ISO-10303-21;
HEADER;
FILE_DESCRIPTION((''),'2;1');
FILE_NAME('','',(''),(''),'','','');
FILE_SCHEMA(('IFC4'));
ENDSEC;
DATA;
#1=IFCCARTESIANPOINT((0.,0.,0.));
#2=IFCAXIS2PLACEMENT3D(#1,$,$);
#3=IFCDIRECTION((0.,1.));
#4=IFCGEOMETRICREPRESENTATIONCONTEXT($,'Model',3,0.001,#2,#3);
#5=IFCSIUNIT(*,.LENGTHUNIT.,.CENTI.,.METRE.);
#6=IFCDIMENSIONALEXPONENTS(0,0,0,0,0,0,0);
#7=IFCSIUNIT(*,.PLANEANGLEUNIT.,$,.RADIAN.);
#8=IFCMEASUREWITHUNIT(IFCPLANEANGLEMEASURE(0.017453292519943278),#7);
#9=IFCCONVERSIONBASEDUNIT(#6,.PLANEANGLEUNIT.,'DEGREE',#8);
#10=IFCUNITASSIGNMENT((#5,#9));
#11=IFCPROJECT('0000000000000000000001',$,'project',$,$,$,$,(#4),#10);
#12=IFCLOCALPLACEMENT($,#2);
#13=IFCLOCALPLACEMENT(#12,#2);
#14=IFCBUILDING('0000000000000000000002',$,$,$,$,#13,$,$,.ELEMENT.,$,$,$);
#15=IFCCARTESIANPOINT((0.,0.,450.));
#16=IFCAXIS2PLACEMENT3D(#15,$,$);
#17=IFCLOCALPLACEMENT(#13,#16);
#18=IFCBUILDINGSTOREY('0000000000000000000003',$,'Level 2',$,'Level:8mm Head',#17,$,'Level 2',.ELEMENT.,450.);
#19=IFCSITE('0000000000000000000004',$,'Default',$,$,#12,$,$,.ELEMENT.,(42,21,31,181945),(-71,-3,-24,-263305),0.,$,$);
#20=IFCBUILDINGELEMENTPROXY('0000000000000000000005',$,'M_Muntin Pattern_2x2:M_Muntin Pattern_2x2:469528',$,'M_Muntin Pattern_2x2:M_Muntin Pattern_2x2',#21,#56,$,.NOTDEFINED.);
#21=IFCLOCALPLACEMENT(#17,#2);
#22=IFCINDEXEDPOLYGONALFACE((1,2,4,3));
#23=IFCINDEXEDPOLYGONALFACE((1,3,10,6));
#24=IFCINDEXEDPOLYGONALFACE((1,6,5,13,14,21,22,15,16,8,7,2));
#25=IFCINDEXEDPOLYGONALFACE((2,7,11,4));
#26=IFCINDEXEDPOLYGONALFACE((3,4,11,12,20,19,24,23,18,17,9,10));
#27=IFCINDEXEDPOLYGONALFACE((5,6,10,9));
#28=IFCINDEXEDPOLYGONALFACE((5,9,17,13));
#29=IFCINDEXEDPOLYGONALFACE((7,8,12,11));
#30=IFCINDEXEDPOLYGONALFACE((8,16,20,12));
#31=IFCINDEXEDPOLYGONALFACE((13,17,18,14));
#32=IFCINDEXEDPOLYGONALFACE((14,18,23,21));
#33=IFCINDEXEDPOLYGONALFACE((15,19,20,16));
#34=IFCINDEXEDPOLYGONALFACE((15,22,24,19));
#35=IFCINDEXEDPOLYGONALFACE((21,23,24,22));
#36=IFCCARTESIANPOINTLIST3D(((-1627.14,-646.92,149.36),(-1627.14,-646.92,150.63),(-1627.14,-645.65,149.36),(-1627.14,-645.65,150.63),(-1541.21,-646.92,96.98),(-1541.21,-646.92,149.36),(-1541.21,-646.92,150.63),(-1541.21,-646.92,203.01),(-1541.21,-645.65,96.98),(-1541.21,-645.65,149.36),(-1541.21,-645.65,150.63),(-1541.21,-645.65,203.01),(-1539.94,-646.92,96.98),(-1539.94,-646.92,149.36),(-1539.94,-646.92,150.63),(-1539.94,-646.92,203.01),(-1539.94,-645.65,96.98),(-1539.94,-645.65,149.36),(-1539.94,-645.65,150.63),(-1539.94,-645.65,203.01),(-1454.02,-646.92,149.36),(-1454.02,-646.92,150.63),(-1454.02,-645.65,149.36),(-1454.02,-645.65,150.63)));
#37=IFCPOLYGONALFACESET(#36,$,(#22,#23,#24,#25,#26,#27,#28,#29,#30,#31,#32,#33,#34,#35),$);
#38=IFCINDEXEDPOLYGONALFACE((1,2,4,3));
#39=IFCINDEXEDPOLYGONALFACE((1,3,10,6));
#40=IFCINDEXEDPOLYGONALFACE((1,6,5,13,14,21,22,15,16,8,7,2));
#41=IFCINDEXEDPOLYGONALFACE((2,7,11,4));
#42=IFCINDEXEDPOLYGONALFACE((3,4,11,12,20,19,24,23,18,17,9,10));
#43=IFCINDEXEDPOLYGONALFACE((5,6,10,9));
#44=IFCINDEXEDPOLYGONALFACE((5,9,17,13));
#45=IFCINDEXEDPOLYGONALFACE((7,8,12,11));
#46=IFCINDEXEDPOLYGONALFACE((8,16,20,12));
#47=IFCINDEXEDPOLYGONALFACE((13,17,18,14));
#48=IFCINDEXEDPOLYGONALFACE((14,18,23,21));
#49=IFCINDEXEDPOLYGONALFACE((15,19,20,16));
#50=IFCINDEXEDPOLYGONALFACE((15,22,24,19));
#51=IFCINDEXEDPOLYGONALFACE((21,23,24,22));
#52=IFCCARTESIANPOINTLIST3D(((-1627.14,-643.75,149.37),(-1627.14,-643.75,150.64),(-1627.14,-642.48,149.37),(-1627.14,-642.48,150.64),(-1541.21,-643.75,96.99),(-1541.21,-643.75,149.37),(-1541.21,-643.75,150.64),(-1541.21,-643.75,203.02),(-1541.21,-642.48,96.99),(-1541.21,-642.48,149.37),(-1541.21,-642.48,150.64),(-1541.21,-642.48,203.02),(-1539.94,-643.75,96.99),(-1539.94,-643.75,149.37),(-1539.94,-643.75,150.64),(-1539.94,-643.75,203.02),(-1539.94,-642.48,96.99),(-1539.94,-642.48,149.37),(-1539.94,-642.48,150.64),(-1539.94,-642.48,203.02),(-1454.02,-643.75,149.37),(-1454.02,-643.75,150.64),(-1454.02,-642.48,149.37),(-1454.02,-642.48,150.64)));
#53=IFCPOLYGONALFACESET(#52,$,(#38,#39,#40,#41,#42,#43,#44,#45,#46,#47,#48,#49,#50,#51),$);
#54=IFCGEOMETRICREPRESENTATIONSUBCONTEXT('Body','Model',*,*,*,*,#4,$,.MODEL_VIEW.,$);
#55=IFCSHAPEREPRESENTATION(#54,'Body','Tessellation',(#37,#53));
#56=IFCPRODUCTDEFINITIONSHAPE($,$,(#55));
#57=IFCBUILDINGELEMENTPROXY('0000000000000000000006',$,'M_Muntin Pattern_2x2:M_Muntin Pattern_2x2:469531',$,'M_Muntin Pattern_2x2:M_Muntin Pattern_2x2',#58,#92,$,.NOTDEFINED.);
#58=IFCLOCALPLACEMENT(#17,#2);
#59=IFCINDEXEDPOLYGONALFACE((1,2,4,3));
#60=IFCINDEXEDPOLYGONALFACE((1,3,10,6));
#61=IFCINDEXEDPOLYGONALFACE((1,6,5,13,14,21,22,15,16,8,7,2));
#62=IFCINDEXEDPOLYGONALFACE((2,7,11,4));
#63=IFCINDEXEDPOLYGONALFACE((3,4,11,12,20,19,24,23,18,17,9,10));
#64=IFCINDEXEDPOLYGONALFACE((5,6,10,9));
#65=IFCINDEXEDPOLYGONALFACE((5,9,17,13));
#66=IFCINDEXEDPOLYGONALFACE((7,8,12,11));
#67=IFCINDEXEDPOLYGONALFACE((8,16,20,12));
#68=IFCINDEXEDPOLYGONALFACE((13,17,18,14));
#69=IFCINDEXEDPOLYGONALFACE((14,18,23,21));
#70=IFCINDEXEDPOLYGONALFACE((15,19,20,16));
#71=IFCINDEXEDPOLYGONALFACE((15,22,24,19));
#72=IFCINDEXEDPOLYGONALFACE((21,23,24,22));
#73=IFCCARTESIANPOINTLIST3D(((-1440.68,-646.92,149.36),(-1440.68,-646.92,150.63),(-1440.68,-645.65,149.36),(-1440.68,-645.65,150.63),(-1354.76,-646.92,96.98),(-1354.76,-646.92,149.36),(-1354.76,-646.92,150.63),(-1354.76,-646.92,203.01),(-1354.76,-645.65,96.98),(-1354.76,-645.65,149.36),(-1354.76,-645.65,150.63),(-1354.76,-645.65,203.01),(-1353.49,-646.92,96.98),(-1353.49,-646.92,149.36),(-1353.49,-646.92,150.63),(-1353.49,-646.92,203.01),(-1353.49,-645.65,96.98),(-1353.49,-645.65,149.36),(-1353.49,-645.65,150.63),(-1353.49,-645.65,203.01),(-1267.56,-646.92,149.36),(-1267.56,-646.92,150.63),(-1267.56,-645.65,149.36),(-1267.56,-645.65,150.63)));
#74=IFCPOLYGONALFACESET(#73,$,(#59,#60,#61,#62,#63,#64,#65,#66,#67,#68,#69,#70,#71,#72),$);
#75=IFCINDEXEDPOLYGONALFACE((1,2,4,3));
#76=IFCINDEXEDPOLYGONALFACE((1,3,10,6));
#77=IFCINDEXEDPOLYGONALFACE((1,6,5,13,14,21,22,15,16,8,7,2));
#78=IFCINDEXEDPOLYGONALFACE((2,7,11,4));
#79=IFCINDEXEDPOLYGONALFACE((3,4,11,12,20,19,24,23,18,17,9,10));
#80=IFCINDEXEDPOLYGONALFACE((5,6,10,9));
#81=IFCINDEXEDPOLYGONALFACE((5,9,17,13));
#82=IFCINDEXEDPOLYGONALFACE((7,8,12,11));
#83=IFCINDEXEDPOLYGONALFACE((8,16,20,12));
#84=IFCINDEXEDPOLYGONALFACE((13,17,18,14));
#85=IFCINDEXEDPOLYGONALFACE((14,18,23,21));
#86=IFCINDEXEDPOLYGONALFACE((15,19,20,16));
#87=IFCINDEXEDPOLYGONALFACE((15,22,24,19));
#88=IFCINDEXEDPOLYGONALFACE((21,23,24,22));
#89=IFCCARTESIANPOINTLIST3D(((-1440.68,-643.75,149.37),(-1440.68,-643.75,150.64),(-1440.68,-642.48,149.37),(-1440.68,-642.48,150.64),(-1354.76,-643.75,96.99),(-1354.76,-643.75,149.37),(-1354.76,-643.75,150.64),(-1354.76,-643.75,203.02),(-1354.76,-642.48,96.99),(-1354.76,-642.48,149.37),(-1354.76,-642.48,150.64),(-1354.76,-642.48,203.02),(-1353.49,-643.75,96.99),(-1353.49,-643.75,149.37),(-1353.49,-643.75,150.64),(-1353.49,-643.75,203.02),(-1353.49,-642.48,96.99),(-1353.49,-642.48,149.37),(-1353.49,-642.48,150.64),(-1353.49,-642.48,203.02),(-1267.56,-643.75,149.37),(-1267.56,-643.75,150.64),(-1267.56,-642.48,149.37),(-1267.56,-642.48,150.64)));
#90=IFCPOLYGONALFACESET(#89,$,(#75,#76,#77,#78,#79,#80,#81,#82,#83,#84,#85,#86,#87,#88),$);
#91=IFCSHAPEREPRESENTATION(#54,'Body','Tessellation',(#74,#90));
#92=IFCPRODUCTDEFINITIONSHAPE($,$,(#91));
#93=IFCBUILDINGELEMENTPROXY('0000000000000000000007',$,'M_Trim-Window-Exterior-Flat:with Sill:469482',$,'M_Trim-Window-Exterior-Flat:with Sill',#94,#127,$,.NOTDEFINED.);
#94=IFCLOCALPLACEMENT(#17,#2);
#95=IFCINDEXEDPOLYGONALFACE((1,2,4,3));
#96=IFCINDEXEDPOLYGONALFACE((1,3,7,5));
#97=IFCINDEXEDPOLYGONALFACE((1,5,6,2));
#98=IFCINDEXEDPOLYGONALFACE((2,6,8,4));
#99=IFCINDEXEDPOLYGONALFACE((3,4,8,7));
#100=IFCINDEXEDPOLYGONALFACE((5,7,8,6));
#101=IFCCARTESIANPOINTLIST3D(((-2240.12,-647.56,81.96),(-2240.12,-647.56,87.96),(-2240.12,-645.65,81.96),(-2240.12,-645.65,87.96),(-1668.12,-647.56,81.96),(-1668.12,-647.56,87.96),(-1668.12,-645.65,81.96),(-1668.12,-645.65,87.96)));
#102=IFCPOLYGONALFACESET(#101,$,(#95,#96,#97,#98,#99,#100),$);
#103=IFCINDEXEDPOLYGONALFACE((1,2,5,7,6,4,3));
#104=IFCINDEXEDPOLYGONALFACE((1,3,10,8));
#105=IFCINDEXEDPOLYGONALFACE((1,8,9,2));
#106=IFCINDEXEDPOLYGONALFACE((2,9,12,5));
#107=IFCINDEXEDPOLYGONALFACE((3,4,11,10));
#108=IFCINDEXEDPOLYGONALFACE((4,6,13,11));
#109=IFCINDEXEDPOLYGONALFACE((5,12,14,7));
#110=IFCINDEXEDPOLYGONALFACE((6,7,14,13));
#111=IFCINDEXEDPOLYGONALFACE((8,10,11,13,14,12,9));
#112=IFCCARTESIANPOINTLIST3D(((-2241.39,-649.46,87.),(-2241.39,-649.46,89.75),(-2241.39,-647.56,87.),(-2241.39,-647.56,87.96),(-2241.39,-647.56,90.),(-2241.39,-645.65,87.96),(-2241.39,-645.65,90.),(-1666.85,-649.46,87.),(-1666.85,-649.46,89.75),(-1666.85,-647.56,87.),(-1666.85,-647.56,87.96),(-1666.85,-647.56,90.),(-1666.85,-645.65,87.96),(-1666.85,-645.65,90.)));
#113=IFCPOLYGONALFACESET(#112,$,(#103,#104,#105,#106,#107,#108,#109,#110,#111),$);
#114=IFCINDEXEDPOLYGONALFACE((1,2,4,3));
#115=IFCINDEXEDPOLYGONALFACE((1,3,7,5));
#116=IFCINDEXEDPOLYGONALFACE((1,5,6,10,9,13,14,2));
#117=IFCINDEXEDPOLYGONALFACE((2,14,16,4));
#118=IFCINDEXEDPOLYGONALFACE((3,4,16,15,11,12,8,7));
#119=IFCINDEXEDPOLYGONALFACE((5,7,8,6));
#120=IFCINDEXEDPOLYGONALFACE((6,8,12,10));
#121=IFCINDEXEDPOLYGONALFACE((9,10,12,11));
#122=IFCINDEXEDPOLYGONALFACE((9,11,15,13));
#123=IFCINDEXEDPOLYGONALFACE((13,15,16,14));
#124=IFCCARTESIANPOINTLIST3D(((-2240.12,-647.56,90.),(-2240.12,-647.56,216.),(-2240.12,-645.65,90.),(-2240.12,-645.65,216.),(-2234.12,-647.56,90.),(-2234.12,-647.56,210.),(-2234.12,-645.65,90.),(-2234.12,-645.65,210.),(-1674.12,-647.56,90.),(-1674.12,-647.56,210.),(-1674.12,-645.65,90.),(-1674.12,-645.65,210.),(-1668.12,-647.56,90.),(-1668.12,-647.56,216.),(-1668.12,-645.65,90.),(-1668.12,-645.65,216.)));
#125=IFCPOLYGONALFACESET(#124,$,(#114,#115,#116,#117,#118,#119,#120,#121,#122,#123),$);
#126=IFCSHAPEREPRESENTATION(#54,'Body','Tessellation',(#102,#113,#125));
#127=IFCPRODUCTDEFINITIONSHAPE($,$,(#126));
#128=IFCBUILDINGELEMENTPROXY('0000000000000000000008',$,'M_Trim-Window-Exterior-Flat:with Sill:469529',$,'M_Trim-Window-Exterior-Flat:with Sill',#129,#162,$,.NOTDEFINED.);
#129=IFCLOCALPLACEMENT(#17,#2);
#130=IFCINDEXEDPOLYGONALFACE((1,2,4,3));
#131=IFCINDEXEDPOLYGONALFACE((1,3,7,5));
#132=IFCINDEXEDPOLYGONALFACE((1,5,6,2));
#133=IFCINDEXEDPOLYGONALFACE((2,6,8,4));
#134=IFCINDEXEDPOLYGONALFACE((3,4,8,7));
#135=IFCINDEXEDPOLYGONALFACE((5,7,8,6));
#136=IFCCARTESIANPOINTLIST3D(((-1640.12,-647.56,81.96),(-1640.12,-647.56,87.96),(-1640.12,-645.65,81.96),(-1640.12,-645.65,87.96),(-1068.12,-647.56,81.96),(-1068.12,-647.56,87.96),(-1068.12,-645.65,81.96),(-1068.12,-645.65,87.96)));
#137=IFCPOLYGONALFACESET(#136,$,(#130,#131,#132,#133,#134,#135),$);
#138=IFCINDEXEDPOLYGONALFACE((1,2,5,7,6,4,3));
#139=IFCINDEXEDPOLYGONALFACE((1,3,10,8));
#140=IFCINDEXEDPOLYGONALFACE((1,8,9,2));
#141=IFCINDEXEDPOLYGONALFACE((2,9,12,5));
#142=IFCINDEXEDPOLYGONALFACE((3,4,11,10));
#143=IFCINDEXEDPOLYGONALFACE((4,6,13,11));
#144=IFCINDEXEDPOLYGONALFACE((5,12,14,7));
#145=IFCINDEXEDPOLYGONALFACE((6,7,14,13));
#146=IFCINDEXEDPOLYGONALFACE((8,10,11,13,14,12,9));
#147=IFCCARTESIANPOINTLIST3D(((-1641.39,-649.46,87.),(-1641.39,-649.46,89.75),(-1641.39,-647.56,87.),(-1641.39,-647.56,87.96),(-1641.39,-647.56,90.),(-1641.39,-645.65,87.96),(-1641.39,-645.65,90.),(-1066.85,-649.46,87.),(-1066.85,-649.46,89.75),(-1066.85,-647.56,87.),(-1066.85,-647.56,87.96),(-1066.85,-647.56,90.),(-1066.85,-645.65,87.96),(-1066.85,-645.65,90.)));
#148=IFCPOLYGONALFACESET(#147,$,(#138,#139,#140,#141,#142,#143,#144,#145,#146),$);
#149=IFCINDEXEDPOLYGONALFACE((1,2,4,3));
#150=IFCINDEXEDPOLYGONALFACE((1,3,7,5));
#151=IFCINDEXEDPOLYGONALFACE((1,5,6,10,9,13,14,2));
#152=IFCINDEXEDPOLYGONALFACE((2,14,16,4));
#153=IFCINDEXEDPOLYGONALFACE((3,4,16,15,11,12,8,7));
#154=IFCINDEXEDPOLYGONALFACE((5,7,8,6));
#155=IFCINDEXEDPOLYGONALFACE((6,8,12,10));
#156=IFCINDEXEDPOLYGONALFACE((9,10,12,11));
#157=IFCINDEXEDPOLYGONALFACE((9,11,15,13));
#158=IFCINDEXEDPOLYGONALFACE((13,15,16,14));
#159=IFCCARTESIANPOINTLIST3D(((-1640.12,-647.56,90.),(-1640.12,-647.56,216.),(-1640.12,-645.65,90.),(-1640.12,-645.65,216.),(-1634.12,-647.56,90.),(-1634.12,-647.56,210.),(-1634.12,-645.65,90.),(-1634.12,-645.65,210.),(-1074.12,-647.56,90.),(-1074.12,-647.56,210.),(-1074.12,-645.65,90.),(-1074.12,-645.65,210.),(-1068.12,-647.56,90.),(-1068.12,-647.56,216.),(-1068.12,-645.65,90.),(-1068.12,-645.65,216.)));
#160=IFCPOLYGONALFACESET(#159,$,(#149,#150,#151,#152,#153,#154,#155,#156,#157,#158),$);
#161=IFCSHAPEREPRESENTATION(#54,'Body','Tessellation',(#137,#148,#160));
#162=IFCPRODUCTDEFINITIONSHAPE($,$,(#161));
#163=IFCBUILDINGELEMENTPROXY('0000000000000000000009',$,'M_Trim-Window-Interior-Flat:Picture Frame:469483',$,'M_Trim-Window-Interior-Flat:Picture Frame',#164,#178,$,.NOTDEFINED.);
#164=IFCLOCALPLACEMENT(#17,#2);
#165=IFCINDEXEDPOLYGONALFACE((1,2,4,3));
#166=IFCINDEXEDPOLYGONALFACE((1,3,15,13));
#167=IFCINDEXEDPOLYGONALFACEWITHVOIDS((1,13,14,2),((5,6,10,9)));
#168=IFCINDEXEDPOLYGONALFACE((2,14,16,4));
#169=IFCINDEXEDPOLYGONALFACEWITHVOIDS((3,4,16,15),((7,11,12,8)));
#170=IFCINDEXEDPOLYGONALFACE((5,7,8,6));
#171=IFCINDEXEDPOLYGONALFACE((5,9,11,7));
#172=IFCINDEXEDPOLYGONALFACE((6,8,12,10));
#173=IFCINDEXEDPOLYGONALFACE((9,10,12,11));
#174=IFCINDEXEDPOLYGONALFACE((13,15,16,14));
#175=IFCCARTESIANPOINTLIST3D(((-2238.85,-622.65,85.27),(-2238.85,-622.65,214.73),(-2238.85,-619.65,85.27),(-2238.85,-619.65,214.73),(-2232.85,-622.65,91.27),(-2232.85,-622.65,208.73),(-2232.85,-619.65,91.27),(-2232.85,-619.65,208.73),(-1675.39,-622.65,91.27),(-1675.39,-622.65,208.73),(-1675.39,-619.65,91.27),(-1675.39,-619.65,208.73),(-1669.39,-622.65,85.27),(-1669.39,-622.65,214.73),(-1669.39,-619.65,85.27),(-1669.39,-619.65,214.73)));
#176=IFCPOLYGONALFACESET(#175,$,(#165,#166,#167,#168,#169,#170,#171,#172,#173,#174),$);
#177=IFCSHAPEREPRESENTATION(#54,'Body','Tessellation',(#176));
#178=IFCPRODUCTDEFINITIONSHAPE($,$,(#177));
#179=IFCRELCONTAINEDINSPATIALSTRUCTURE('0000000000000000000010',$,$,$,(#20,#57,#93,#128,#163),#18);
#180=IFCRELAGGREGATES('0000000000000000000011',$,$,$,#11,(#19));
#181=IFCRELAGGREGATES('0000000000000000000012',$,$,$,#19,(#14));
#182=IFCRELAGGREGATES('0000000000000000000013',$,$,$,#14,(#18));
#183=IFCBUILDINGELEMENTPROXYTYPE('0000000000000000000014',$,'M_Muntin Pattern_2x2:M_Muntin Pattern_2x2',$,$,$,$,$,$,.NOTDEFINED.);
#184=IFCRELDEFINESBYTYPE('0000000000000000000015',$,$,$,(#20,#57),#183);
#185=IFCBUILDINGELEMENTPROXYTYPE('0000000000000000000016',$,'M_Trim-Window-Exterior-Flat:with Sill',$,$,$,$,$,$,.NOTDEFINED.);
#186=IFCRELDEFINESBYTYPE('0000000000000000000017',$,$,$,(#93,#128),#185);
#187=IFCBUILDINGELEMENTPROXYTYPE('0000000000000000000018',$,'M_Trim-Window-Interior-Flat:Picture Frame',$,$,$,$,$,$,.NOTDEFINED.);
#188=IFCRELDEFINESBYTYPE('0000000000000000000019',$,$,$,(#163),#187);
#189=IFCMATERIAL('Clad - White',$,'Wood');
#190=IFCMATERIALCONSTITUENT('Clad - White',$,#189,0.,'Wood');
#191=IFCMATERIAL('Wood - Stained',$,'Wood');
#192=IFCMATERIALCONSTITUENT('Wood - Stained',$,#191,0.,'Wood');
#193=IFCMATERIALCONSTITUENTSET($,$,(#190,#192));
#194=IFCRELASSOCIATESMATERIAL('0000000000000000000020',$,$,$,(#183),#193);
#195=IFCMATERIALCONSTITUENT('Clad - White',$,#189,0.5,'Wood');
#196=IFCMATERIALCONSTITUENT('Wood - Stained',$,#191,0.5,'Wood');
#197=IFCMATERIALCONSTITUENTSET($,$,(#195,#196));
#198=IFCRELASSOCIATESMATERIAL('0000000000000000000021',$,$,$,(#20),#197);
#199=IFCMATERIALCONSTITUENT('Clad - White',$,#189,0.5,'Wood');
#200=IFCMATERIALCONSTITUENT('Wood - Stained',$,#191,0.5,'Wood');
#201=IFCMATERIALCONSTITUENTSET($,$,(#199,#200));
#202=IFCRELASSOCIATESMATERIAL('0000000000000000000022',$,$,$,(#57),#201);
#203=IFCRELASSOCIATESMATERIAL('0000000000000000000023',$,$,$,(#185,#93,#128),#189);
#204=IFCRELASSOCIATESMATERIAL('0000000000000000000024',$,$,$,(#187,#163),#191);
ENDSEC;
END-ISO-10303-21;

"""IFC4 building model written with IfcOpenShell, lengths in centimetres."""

from ifc_helpers import new_model, entity, si_unit, converted_unit, direction, frame, origin, place, context, subcontext, project, spatial, indexed_curve, outline, extrude, source, transform, mapped, material, constituent, constituent_set, type_object, type_shapes, element, save


model = new_model("IFC4")

# Units and contexts
model_context = context("Model", 3, precision=0.001, world=origin(), true_north=direction((0.0, 1.0)))
body_context = subcontext(model_context, "Body", "Model", "MODEL_VIEW")
ifc_project = project(units=[si_unit("LENGTHUNIT", "METRE", prefix="CENTI"), converted_unit("PLANEANGLEUNIT", "DEGREE", entity("IfcPlaneAngleMeasure", 0.017453292519943278), si_unit("PLANEANGLEUNIT", "RADIAN"), dimensions=[0, 0, 0, 0, 0, 0, 0])], contexts=[model_context])

# Site, building, storey
site_placement = place(None, origin())
site = spatial("IfcSite", under=ifc_project, at=site_placement, Name="Default", CompositionType="ELEMENT", RefLatitude=(42, 21, 31, 181945), RefLongitude=(-71, -3, -24, -263305), RefElevation=0.0)
building_placement = place(site_placement, origin())
building = spatial("IfcBuilding", under=site, at=building_placement, CompositionType="ELEMENT")
storey_placement = place(building_placement, frame((0.0, 0.0, 450.0)))
storey = spatial("IfcBuildingStorey", under=building, at=storey_placement, Name="Level 2", ObjectType="Level:8mm Head", LongName="Level 2", CompositionType="ELEMENT", Elevation=450.0)

# Building element proxies
ifc_material_1 = material(Name="Clad - White", Category="Wood")
ifc_material_2 = material(Name="Wood - Stained", Category="Wood")
ifc_constituent_1 = constituent(ifc_material_1, Name="Clad - White", Category="Wood", fraction=0.0)
ifc_constituent_2 = constituent(ifc_material_2, Name="Wood - Stained", Category="Wood", fraction=0.0)
ifc_constituent_set_1 = constituent_set(constituents=[ifc_constituent_1, ifc_constituent_2])
building_element_proxy_type_1 = type_object("IfcBuildingElementProxyType", Name="M_Muntin Pattern_2x2:M_Muntin Pattern_2x2", PredefinedType="NOTDEFINED", material=ifc_constituent_set_1)
shared_shape_1 = source(origin(), body_context, "Body", "SweptSolid", [
    extrude(outline(indexed_curve([(0.64, -0.64), (53.01, -0.64), (53.01, 0.63), (0.64, 0.63), (0.64, 86.56), (-0.63, 86.56), (-0.63, 0.63), (-53.02, 0.63), (-53.02, -0.64), (-0.63, -0.64), (-0.63, -86.56), (0.64, -86.56), (0.64, -0.64)], self_intersect=False)), frame((0.0, -2.22, 53.01), z_axis=(0.0, 1.0, 0.0), x_axis=(0.0, 0.0, 1.0)), (0.0, 0.0, 1.0), 1.27),
    extrude(outline(indexed_curve([(0.64, -0.64), (53.02, -0.64), (53.02, 0.63), (0.64, 0.63), (0.64, 86.56), (-0.63, 86.56), (-0.63, 0.63), (-53.02, 0.63), (-53.02, -0.64), (-0.63, -0.64), (-0.63, -86.56), (0.64, -86.56), (0.64, -0.64)], self_intersect=False)), frame((0.0, 0.95, 53.02), z_axis=(0.0, 1.0, 0.0), x_axis=(0.0, 0.0, 1.0)), (0.0, 0.0, 1.0), 1.27),
])
type_shapes(building_element_proxy_type_1, [shared_shape_1])
ifc_constituent_3 = constituent(ifc_material_1, Name="Clad - White", Category="Wood", fraction=0.5)
ifc_constituent_4 = constituent(ifc_material_2, Name="Wood - Stained", Category="Wood", fraction=0.5)
ifc_constituent_set_2 = constituent_set(constituents=[ifc_constituent_3, ifc_constituent_4])
proxy_1_placement = place(storey_placement, frame((-1540.58, -644.7, 96.99)))
element("IfcBuildingElementProxy", 1, at=proxy_1_placement, inside=storey, type_object=building_element_proxy_type_1, material=ifc_constituent_set_2, Name="M_Muntin Pattern_2x2:M_Muntin Pattern_2x2:469528", ObjectType="M_Muntin Pattern_2x2:M_Muntin Pattern_2x2", PredefinedType="NOTDEFINED", context=body_context, shape_type="MappedRepresentation", body=[
    mapped(shared_shape_1, transform((0.0, 0.0, 0.0), scale=1.0)),
])
ifc_constituent_5 = constituent(ifc_material_1, Name="Clad - White", Category="Wood", fraction=0.5)
ifc_constituent_6 = constituent(ifc_material_2, Name="Wood - Stained", Category="Wood", fraction=0.5)
ifc_constituent_set_3 = constituent_set(constituents=[ifc_constituent_5, ifc_constituent_6])
proxy_2_placement = place(storey_placement, frame((-1354.12, -644.7, 96.99)))
element("IfcBuildingElementProxy", 2, at=proxy_2_placement, inside=storey, type_object=building_element_proxy_type_1, material=ifc_constituent_set_3, Name="M_Muntin Pattern_2x2:M_Muntin Pattern_2x2:469531", ObjectType="M_Muntin Pattern_2x2:M_Muntin Pattern_2x2", PredefinedType="NOTDEFINED", context=body_context, shape_type="MappedRepresentation", body=[
    mapped(shared_shape_1, transform((0.0, 0.0, 0.0), scale=1.0)),
])
building_element_proxy_type_2 = type_object("IfcBuildingElementProxyType", Name="M_Trim-Window-Exterior-Flat:with Sill", PredefinedType="NOTDEFINED", material=ifc_material_1)
shared_shape_2 = source(origin(), body_context, "Body", "SweptSolid", [
    extrude(outline(indexed_curve([(-286.0, -3.0), (286.0, -3.0), (286.0, 3.0), (-286.0, 3.0), (-286.0, -3.0)], self_intersect=False)), frame((0.0, -125.04, 0.0), z_axis=(0.0, 0.0, 1.0), x_axis=(-1.0, 0.0, 0.0)), (0.0, 0.0, 1.0), 1.9),
    extrude(outline(indexed_curve([(-1.9, -1.52), (0.0, -1.52), (0.0, -0.57), (1.9, -0.57), (1.9, 1.48), (0.0, 1.48), (-1.9, 1.23), (-1.9, -1.52)], self_intersect=False)), frame((-287.27, -121.48, 1.9), z_axis=(1.0, 0.0, 0.0), x_axis=(0.0, 0.0, -1.0)), (0.0, 0.0, 1.0), 574.54),
    extrude(outline(indexed_curve([(-64.5, -286.0), (61.5, -286.0), (61.5, -280.0), (-58.5, -280.0), (-58.5, 280.0), (61.5, 280.0), (61.5, 286.0), (-64.5, 286.0), (-64.5, -286.0)], self_intersect=False)), frame((0.0, -58.5, 0.0), z_axis=(0.0, 0.0, 1.0), x_axis=(0.0, -1.0, 0.0)), (0.0, 0.0, 1.0), 1.9),
])
type_shapes(building_element_proxy_type_2, [shared_shape_2])
for number, where, z_axis, x_axis, name in (
    (3, (-1954.12, -645.65, 210.0), (0.0, -1.0, 0.0), (1.0, 0.0, 0.0), "M_Trim-Window-Exterior-Flat:with Sill:469482"),
    (4, (-1354.12, -645.65, 210.0), (0.0, -1.0, 0.0), (1.0, 0.0, 0.0), "M_Trim-Window-Exterior-Flat:with Sill:469529"),
):
    element("IfcBuildingElementProxy", number, at=place(storey_placement, frame(where, z_axis=z_axis, x_axis=x_axis)), inside=storey, type_object=building_element_proxy_type_2, material=ifc_material_1, Name=name, ObjectType="M_Trim-Window-Exterior-Flat:with Sill", PredefinedType="NOTDEFINED", context=body_context, shape_type="MappedRepresentation", body=[
        mapped(shared_shape_2, transform((0.0, 0.0, 0.0), scale=1.0)),
    ])
building_element_proxy_type_3 = type_object("IfcBuildingElementProxyType", Name="M_Trim-Window-Interior-Flat:Picture Frame", PredefinedType="NOTDEFINED", material=ifc_material_2)
shared_shape_3 = source(origin(), body_context, "Body", "SweptSolid", [
    extrude(outline(indexed_curve([(-284.73, -64.73), (284.73, -64.73), (284.73, 64.73), (-284.73, 64.73), (-284.73, -64.73)], self_intersect=False), holes=[indexed_curve([(-278.73, -58.73), (-278.73, 58.73), (278.73, 58.73), (278.73, -58.73), (-278.73, -58.73)], self_intersect=False)]), frame((0.0, -60.0, 0.0), z_axis=(0.0, 0.0, 1.0), x_axis=(-1.0, 0.0, 0.0)), (0.0, 0.0, 1.0), 3.0),
])
type_shapes(building_element_proxy_type_3, [shared_shape_3])
for number, where, z_axis, x_axis, name in (
    (5, (-1954.12, -622.65, 210.0), (0.0, 1.0, 0.0), (-1.0, 0.0, 0.0), "M_Trim-Window-Interior-Flat:Picture Frame:469483"),
):
    element("IfcBuildingElementProxy", number, at=place(storey_placement, frame(where, z_axis=z_axis, x_axis=x_axis)), inside=storey, type_object=building_element_proxy_type_3, material=ifc_material_2, Name=name, ObjectType="M_Trim-Window-Interior-Flat:Picture Frame", PredefinedType="NOTDEFINED", context=body_context, shape_type="MappedRepresentation", body=[
        mapped(shared_shape_3, transform((0.0, 0.0, 0.0), scale=1.0)),
    ])

save(model, "model.ifc")
